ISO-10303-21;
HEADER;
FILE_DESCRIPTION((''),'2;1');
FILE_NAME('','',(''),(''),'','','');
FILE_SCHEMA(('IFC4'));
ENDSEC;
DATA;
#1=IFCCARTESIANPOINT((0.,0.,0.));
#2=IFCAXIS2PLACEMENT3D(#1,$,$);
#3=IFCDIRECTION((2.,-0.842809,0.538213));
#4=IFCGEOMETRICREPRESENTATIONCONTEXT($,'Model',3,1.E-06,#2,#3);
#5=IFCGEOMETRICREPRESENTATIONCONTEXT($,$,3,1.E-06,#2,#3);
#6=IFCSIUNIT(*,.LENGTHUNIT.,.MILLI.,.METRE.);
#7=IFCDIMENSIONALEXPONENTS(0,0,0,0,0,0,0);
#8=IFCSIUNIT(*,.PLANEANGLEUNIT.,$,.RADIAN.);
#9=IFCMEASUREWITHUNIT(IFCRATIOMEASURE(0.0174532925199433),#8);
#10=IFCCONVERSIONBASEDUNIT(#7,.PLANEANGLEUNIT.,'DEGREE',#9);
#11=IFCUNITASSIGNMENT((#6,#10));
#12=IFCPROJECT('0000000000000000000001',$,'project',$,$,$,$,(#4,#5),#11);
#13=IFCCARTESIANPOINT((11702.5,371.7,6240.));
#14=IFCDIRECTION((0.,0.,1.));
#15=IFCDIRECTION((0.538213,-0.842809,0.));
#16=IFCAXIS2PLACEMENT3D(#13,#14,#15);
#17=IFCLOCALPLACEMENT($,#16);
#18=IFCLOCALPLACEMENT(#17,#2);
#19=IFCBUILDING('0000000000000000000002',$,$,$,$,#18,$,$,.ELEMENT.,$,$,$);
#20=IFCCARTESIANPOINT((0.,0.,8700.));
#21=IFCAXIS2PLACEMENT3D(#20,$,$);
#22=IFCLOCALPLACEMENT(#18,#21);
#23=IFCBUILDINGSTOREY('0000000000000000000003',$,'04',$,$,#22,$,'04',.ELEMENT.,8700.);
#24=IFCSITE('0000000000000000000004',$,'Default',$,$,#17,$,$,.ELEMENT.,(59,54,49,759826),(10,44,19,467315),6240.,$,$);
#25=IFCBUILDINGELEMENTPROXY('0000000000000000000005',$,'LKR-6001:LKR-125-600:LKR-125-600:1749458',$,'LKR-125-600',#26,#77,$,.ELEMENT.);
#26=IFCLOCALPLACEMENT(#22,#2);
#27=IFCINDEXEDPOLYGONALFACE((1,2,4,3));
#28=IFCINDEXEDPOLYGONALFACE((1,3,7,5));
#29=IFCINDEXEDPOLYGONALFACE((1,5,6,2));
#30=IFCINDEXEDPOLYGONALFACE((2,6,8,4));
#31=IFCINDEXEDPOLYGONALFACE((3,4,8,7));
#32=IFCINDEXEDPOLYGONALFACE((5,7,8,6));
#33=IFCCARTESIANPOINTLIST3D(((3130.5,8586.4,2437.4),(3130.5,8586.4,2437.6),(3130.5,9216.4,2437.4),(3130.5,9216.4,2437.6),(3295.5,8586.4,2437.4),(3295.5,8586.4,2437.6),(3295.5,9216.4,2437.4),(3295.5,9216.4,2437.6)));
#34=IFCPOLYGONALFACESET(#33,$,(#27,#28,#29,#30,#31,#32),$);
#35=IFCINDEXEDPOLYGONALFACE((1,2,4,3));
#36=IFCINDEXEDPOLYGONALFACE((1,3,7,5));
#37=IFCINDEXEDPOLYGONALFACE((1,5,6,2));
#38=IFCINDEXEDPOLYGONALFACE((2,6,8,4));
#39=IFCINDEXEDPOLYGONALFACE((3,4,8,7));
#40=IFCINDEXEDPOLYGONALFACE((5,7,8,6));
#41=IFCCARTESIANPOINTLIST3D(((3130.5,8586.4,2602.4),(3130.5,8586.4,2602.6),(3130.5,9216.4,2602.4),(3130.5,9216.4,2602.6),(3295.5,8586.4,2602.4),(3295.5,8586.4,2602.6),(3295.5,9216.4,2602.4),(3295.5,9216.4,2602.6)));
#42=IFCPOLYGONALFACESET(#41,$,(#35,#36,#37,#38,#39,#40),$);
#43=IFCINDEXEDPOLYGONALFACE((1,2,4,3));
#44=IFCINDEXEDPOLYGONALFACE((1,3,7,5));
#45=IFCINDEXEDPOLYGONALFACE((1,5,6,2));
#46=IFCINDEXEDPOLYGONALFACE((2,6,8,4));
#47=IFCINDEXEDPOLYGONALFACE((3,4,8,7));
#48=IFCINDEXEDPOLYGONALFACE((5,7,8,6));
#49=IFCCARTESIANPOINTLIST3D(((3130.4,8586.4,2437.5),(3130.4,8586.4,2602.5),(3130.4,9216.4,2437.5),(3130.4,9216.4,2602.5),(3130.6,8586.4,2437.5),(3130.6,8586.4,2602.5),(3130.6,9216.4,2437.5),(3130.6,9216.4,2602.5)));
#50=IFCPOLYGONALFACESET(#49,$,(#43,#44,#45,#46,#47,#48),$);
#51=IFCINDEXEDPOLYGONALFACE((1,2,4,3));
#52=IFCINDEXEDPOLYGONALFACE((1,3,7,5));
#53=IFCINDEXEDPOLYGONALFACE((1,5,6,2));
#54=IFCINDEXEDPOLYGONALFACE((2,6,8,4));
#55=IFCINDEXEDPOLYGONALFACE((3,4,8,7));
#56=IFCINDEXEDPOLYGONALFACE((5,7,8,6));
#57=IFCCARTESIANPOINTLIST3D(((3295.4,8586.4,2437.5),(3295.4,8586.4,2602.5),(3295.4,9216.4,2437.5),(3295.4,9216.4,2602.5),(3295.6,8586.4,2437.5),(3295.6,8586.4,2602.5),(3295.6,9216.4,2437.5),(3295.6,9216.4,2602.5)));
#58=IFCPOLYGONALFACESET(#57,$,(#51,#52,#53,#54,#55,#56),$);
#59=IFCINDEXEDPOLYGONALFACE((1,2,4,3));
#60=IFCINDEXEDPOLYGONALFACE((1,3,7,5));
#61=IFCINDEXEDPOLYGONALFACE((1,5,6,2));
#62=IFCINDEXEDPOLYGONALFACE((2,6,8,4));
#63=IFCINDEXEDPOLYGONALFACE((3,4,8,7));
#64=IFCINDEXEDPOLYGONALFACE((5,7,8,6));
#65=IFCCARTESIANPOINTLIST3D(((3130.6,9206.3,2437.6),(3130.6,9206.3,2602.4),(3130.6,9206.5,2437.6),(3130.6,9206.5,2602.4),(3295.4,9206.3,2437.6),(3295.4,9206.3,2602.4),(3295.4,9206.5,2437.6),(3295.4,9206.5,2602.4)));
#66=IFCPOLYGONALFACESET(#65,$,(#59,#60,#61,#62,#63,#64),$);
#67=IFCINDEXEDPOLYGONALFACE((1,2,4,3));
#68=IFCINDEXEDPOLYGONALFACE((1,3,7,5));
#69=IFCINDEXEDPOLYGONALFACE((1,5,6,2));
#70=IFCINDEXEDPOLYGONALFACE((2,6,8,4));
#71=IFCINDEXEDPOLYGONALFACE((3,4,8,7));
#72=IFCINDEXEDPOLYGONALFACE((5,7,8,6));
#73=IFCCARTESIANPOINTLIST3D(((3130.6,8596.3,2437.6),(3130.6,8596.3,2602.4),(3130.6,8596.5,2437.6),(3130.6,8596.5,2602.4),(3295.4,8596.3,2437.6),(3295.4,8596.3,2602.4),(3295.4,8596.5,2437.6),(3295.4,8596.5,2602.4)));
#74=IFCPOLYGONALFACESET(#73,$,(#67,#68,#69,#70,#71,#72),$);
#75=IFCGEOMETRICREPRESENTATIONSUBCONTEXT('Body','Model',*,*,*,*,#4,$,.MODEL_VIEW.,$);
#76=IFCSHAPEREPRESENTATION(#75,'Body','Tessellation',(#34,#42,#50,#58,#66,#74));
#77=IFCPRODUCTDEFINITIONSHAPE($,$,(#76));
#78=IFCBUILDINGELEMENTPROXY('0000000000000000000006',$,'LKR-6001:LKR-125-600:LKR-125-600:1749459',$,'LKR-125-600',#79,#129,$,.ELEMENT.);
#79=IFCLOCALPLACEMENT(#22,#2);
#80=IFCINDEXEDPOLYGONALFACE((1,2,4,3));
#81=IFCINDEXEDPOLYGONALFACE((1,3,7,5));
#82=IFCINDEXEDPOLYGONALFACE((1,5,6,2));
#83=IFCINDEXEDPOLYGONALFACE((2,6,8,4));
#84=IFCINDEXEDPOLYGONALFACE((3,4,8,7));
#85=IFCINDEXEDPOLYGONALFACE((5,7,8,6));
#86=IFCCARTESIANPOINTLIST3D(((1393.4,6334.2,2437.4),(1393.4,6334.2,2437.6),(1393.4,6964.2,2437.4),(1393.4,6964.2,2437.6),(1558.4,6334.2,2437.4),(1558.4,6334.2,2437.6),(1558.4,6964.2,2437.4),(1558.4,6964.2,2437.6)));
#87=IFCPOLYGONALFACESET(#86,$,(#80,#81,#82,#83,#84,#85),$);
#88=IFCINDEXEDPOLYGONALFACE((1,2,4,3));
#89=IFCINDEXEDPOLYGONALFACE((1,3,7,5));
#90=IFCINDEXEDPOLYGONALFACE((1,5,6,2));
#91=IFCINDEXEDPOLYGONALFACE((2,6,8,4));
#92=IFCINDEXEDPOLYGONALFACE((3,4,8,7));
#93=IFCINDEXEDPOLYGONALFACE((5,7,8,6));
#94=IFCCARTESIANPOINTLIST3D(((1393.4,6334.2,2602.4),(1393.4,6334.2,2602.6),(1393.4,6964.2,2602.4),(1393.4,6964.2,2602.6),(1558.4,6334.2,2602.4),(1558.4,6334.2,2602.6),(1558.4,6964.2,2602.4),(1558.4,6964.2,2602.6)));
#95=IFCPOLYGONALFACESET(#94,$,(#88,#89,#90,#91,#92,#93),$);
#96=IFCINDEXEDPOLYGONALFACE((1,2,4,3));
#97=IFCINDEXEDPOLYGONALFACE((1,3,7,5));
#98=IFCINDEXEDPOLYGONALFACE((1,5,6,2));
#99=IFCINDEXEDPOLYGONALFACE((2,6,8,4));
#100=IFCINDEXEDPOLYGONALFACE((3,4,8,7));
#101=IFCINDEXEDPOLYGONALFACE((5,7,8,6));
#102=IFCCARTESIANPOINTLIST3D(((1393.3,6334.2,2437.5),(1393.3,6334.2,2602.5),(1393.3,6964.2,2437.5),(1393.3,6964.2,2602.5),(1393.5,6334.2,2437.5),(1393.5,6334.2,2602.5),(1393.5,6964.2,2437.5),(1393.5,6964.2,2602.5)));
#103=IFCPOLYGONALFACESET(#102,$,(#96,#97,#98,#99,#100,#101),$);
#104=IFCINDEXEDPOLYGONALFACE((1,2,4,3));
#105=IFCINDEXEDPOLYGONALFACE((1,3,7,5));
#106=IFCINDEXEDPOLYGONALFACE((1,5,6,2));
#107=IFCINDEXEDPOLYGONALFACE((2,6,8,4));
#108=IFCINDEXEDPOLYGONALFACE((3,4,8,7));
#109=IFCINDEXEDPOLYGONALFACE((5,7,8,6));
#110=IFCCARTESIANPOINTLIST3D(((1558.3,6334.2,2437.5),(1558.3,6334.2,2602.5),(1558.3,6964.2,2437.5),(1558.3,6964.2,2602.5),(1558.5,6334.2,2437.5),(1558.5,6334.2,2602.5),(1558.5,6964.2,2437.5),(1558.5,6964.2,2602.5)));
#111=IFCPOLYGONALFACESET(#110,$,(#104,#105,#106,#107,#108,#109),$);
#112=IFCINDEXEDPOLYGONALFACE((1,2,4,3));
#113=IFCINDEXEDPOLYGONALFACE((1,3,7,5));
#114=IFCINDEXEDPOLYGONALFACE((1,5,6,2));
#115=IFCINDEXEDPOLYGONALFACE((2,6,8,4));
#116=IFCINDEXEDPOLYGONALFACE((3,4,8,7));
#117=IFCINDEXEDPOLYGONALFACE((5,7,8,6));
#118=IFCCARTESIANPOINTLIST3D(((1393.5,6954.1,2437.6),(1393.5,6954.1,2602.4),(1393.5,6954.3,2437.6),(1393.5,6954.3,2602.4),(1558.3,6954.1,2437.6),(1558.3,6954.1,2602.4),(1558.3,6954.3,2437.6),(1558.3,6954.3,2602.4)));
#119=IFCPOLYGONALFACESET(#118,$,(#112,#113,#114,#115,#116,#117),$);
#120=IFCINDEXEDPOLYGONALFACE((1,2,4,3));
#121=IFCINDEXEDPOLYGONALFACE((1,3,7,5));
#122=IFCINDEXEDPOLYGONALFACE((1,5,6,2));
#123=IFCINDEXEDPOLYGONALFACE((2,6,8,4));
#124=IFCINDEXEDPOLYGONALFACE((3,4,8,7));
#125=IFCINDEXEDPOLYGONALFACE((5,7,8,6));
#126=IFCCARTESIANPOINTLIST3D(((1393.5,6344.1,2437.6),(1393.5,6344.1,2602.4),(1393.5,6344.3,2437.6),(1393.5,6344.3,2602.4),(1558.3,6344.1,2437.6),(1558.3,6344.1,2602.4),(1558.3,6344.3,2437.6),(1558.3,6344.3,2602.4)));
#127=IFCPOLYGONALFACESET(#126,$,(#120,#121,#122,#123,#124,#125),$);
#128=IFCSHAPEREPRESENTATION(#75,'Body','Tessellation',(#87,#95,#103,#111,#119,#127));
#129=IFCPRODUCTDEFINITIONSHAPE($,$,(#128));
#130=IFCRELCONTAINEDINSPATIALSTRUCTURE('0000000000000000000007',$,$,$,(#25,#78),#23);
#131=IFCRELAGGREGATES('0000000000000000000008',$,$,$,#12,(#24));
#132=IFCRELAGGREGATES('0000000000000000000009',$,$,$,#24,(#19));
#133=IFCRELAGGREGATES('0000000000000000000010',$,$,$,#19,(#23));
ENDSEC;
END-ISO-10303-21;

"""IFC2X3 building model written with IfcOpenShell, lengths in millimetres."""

from ifc_helpers import new_model, entity, si_unit, converted_unit, direction, frame, frame_2d, origin, place, context, subcontext, project, spatial, rectangle, extrude, source, transform, mapped, element, save


model = new_model("IFC2X3")

# Units and contexts
model_context = context("Model", 3, precision=1e-06, world=origin(), true_north=direction((2.0, -0.842809, 0.538213)))
context_of_model = context(None, 3, precision=1e-06, world=origin(), true_north=direction((2.0, -0.842809, 0.538213)))
body_context = subcontext(model_context, "Body", "Model", "MODEL_VIEW")
ifc_project = project(units=[si_unit("LENGTHUNIT", "METRE", prefix="MILLI"), converted_unit("PLANEANGLEUNIT", "DEGREE", entity("IfcRatioMeasure", 0.0174532925199433), si_unit("PLANEANGLEUNIT", "RADIAN"), dimensions=[0, 0, 0, 0, 0, 0, 0])], contexts=[model_context, context_of_model])

# Site, building, storey
site_placement = place(None, frame((11702.5, 371.7, 6240.0), z_axis=(0.0, 0.0, 1.0), x_axis=(0.538213, -0.842809, 0.0)))
site = spatial("IfcSite", under=ifc_project, at=site_placement, Name="Default", CompositionType="ELEMENT", RefLatitude=(59, 54, 49, 759826), RefLongitude=(10, 44, 19, 467315), RefElevation=6240.0)
building_placement = place(site_placement, origin())
building = spatial("IfcBuilding", under=site, at=building_placement, CompositionType="ELEMENT")
storey_placement = place(building_placement, frame((0.0, 0.0, 8700.0)))
storey = spatial("IfcBuildingStorey", under=building, at=storey_placement, Name="04", LongName="04", CompositionType="ELEMENT", Elevation=8700.0)

# Building element proxies
shared_shape_1 = source(origin(), body_context, "Body", "SweptSolid", [
    extrude(rectangle(XDim=165.0, YDim=630.0, at=frame_2d((0.0, 0.0), x_axis=(1.0, 0.0))), frame((0.0, 0.0, -82.6), z_axis=(0.0, 0.0, 1.0), x_axis=(0.0, -1.0, 0.0)), (0.0, 0.0, 1.0), 0.2),
    extrude(rectangle(XDim=165.0, YDim=630.0, at=frame_2d((0.0, 0.0), x_axis=(1.0, 0.0))), frame((0.0, 0.0, 82.4), z_axis=(0.0, 0.0, 1.0), x_axis=(0.0, -1.0, 0.0)), (0.0, 0.0, 1.0), 0.2),
    extrude(rectangle(XDim=0.2, YDim=630.0, at=frame_2d((0.0, 0.0), x_axis=(1.0, 0.0))), frame((0.0, 82.5, -82.5), z_axis=(0.0, 0.0, 1.0), x_axis=(0.0, 1.0, 0.0)), (0.0, 0.0, 1.0), 165.0),
    extrude(rectangle(XDim=0.2, YDim=630.0, at=frame_2d((0.0, 0.0), x_axis=(1.0, 0.0))), frame((0.0, -82.5, -82.5), z_axis=(0.0, 0.0, 1.0), x_axis=(0.0, 1.0, 0.0)), (0.0, 0.0, 1.0), 165.0),
    extrude(rectangle(XDim=0.2, YDim=164.8, at=frame_2d((0.0, 0.0), x_axis=(1.0, 0.0))), frame((305.0, 0.0, -82.4)), (0.0, 0.0, 1.0), 164.8),
    extrude(rectangle(XDim=0.2, YDim=164.8, at=frame_2d((0.0, 0.0), x_axis=(1.0, 0.0))), frame((-305.0, 0.0, -82.4)), (0.0, 0.0, 1.0), 164.8),
])
for number, where, z_axis, x_axis, name in (
    (1, (3213.0, 8901.4, 2520.0), (0.0, 0.0, 1.0), (0.0, 1.0, 0.0), "LKR-6001:LKR-125-600:LKR-125-600:1749458"),
    (2, (1475.9, 6649.2, 2520.0), (0.0, 0.0, 1.0), (0.0, 1.0, 0.0), "LKR-6001:LKR-125-600:LKR-125-600:1749459"),
):
    element("IfcBuildingElementProxy", number, at=place(storey_placement, frame(where, z_axis=z_axis, x_axis=x_axis)), inside=storey, Name=name, ObjectType="LKR-125-600", CompositionType="ELEMENT", context=body_context, shape_type="MappedRepresentation", body=[
        mapped(shared_shape_1, transform((0.0, 0.0, 0.0), scale=1.0)),
    ])

save(model, "model.ifc")
